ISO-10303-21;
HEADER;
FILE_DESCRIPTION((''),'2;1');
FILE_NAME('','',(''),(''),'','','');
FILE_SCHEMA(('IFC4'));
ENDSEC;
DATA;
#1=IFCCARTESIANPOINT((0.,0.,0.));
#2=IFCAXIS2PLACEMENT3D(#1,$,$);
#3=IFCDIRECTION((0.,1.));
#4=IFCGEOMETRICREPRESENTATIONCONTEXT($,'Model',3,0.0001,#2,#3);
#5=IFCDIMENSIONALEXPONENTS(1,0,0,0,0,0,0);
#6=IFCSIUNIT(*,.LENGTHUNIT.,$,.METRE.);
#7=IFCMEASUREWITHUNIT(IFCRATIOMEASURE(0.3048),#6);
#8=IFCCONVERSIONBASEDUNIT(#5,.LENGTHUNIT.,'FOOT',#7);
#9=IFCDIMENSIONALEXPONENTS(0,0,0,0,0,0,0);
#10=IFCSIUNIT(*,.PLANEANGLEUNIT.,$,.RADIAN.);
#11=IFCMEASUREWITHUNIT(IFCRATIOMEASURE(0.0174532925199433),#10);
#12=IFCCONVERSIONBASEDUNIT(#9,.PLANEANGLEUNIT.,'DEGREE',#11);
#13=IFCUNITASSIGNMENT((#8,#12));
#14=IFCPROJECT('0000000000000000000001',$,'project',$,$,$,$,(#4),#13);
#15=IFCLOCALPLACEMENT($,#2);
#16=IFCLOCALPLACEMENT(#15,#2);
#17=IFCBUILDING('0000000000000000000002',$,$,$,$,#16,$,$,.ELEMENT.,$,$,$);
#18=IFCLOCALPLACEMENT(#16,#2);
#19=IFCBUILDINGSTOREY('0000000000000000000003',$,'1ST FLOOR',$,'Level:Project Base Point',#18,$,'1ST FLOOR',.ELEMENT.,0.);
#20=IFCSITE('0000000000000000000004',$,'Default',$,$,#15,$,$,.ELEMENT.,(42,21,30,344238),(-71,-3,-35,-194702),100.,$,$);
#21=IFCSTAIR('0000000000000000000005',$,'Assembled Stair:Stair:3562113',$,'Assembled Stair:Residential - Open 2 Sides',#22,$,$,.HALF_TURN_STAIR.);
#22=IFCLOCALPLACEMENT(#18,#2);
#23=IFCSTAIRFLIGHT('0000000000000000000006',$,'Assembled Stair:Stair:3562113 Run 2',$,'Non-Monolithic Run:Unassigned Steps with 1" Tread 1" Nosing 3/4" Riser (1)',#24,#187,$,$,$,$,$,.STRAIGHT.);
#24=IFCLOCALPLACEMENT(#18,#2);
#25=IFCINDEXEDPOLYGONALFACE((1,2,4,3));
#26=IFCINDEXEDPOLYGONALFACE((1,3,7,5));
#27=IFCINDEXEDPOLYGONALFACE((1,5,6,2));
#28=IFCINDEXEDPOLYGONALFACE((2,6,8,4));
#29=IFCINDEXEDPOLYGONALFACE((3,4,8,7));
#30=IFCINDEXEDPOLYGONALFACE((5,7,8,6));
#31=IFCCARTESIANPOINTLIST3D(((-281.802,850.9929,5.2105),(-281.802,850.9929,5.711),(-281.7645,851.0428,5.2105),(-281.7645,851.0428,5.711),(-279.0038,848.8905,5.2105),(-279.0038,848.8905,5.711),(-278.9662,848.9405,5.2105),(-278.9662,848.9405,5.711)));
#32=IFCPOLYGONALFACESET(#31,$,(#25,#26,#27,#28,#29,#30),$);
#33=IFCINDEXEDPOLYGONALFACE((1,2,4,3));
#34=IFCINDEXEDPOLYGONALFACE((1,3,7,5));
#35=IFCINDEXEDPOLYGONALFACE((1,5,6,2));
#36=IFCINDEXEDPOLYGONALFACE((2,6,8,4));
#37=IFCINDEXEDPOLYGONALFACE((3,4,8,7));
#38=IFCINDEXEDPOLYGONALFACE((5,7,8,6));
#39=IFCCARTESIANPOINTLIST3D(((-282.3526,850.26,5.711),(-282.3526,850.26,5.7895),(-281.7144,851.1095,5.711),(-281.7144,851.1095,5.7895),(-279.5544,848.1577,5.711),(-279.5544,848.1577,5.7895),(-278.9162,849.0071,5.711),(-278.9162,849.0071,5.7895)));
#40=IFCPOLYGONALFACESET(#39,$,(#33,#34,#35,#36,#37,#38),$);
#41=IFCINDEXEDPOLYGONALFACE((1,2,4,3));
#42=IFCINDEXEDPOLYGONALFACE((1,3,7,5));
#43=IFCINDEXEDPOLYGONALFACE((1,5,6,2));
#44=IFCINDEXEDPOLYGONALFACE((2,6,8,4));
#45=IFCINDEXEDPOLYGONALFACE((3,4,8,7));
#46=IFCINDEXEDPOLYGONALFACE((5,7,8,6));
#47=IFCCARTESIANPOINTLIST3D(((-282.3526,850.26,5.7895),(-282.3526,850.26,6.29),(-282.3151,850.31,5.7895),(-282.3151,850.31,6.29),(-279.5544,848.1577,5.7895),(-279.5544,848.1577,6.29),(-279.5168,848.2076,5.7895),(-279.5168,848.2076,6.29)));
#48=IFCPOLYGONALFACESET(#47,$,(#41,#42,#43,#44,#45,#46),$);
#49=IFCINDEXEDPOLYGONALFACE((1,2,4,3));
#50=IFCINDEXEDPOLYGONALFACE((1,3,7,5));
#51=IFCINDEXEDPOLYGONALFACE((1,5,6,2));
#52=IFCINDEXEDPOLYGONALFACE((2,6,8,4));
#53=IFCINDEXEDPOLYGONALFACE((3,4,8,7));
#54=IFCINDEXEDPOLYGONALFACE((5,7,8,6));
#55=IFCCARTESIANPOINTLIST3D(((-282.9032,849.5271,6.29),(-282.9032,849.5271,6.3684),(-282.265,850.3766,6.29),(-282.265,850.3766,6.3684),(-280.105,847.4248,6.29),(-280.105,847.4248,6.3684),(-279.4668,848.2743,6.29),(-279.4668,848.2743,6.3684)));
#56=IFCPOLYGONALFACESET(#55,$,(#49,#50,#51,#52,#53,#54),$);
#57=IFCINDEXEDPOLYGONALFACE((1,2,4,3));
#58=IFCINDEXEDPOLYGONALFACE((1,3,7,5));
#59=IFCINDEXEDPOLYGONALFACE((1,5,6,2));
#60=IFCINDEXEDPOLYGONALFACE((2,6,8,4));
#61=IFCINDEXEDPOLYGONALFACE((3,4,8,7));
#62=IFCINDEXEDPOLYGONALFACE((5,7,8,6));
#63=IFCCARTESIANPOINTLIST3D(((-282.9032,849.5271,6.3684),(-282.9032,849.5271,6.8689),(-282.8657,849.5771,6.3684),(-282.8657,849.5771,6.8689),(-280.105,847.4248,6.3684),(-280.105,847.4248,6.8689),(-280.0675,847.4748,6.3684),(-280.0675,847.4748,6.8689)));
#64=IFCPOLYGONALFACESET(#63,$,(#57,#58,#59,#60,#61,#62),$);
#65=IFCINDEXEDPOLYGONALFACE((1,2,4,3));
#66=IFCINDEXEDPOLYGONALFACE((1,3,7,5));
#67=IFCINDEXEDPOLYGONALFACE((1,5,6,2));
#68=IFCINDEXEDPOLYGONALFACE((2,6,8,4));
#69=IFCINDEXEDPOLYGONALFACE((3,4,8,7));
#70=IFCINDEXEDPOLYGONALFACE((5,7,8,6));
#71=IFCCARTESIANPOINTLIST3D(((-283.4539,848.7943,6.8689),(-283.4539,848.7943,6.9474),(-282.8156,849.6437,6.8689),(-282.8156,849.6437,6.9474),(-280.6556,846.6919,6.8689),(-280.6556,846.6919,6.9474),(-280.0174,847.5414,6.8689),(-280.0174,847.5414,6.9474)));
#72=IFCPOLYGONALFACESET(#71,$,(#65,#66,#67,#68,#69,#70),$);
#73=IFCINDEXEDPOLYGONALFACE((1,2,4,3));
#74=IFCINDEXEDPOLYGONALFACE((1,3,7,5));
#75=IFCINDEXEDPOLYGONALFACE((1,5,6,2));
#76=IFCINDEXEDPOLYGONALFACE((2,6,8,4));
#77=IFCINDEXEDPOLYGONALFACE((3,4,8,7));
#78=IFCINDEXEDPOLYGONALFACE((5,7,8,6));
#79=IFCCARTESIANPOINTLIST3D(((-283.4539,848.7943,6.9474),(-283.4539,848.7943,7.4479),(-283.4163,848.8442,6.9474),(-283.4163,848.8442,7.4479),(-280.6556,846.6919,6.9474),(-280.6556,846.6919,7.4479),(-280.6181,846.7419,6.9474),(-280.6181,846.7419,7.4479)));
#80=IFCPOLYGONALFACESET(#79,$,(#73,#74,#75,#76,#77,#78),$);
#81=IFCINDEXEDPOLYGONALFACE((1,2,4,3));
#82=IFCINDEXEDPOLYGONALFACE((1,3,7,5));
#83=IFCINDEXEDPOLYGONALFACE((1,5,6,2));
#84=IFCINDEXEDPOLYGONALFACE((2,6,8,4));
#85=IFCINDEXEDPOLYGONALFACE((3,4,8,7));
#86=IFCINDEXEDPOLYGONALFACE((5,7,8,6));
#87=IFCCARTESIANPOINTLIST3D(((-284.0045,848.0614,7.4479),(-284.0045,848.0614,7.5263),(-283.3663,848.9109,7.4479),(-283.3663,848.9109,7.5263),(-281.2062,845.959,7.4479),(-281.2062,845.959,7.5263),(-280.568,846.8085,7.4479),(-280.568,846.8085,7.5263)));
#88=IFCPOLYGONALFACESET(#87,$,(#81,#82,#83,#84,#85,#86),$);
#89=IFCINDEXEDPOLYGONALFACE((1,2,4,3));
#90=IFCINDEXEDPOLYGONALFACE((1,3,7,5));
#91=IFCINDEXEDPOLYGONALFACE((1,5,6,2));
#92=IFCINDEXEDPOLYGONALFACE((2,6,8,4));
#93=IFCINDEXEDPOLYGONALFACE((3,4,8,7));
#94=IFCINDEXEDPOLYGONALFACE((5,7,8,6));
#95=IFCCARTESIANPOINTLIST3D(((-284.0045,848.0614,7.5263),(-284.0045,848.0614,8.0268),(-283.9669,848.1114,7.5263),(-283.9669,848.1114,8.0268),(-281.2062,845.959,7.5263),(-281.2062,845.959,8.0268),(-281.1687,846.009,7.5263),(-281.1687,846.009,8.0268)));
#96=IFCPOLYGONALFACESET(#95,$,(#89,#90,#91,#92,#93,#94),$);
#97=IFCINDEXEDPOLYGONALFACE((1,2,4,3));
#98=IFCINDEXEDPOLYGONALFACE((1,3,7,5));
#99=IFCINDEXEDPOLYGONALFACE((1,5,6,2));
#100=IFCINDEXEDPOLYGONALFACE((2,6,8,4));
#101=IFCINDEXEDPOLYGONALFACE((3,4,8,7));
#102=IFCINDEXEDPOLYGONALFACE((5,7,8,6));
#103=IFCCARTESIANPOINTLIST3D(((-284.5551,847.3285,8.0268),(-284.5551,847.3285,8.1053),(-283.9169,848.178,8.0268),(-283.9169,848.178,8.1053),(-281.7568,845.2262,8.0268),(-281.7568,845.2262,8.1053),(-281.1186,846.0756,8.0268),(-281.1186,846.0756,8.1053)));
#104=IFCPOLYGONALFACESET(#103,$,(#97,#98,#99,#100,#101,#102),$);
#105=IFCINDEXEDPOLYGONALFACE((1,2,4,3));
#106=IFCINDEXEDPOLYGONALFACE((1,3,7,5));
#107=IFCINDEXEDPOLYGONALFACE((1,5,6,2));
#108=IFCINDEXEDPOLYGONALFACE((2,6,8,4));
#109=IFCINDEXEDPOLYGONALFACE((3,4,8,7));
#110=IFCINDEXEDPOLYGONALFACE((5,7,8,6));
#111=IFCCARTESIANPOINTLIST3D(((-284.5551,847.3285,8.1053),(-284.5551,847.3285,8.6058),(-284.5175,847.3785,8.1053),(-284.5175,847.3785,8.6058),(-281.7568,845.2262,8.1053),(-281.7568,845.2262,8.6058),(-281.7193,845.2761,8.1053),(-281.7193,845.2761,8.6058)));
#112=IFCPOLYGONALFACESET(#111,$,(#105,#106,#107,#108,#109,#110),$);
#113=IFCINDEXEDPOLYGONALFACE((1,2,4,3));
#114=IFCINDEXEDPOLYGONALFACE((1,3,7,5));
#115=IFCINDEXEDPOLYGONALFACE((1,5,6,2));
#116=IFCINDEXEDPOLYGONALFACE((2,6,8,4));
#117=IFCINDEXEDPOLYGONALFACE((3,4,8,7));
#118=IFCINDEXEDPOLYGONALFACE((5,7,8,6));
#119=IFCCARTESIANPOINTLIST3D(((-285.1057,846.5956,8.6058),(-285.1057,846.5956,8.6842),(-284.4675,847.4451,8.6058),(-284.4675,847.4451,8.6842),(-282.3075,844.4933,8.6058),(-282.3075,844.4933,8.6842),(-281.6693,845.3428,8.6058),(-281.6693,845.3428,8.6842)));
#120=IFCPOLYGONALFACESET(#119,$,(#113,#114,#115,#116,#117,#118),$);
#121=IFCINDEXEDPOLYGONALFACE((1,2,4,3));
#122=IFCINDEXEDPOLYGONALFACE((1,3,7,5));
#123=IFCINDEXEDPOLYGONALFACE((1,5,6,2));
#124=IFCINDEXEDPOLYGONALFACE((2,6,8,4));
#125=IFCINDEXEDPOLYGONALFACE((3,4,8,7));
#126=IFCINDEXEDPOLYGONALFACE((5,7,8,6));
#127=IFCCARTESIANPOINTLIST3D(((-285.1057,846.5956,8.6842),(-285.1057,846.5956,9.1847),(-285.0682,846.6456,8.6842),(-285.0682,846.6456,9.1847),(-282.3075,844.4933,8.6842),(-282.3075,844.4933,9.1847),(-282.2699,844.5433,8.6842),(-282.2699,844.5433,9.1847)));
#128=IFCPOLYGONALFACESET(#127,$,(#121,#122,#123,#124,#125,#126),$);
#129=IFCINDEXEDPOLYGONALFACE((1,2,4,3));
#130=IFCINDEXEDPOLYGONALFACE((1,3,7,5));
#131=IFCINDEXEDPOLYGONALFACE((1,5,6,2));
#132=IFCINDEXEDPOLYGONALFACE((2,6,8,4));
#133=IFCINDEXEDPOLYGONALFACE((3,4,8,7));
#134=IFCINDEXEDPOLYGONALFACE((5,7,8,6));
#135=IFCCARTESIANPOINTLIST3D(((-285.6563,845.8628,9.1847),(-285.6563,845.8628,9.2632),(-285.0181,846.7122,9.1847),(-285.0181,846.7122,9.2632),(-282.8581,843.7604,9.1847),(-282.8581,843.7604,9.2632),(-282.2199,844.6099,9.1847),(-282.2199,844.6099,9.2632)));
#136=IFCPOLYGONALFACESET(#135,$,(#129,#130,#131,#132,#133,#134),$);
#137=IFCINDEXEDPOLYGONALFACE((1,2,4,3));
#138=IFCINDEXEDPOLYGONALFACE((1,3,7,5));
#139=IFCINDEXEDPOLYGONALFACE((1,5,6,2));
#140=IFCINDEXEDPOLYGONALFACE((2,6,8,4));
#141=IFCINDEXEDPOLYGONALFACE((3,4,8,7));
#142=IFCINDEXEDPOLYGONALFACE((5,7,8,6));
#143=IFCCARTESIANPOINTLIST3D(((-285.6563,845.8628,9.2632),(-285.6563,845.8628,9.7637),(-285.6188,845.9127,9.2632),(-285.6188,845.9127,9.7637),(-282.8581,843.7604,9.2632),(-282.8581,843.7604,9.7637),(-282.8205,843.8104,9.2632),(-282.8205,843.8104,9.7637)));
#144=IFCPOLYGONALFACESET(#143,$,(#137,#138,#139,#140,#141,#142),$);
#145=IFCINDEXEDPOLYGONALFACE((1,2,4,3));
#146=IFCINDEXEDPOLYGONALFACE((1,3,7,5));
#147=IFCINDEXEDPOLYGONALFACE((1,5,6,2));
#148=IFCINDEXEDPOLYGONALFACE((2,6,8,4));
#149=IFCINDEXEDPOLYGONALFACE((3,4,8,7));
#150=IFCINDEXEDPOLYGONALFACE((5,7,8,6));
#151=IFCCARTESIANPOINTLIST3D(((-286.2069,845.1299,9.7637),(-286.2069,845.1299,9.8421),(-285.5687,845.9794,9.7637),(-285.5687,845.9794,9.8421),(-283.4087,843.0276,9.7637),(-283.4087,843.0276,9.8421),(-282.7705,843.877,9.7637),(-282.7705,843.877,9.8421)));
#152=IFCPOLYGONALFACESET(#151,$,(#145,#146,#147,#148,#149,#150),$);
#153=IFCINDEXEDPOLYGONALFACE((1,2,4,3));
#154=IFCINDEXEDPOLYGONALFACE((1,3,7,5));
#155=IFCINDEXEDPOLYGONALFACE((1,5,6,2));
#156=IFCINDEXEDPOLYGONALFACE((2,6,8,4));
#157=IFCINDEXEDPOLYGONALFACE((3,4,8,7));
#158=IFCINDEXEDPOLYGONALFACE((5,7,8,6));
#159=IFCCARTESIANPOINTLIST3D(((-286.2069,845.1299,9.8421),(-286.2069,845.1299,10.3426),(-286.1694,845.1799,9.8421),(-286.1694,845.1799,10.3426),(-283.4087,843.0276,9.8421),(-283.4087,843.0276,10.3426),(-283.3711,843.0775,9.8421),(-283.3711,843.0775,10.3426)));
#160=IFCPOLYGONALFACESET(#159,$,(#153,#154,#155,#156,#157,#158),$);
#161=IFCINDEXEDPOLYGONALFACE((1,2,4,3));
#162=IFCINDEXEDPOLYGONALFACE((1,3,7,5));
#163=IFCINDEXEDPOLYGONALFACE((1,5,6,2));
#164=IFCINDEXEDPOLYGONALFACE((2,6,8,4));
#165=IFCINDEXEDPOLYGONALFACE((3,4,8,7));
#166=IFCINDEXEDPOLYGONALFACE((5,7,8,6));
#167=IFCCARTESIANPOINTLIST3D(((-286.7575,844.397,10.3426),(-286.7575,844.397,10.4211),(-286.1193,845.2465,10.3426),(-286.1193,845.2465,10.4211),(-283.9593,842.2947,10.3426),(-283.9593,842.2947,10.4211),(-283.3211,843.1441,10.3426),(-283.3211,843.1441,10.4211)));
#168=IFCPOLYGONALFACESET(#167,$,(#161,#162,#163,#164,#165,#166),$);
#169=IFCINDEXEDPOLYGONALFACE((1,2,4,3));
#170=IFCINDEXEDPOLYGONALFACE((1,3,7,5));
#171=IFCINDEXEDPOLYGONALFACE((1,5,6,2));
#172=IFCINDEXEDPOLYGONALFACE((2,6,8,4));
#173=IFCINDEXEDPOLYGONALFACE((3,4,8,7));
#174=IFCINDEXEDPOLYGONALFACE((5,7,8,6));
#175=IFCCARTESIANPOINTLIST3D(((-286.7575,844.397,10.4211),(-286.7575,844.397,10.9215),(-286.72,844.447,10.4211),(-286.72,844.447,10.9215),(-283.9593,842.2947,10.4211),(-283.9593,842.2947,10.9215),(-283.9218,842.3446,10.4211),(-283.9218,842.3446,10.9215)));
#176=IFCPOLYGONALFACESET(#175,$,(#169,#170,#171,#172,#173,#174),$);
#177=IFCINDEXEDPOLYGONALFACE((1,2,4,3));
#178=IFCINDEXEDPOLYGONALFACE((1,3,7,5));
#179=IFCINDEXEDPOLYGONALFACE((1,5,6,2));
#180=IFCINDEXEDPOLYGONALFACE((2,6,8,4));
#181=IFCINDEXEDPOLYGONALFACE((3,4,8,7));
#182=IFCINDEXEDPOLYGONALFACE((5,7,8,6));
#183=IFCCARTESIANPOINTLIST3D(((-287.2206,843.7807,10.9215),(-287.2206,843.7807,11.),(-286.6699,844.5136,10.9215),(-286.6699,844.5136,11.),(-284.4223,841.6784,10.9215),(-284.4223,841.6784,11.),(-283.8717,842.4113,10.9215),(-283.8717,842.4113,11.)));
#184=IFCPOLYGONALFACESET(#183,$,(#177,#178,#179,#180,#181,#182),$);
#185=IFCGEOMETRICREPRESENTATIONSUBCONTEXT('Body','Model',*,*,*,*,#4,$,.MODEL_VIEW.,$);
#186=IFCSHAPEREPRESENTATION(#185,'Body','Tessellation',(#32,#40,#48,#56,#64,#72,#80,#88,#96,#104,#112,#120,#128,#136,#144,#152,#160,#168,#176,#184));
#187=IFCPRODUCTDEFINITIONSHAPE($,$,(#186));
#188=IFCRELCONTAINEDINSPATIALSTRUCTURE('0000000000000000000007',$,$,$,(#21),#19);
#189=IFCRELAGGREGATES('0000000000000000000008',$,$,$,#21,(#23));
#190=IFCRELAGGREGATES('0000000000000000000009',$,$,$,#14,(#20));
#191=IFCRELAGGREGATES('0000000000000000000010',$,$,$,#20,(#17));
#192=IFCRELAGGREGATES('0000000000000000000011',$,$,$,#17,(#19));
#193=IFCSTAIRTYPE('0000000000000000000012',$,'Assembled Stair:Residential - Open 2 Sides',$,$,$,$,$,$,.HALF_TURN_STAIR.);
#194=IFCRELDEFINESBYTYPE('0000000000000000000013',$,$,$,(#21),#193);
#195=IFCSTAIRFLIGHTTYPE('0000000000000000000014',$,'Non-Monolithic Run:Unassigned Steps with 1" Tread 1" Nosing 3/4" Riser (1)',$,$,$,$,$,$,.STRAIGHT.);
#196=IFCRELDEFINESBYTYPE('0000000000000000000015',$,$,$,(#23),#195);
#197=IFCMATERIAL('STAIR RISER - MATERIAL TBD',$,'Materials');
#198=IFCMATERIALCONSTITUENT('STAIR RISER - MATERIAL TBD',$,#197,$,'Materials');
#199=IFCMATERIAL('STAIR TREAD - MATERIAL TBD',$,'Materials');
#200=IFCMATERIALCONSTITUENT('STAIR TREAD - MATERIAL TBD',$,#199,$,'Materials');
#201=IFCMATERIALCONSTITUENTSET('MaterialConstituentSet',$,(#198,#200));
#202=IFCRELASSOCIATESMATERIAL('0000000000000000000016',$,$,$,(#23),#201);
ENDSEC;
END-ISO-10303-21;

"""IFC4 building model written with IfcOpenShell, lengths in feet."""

from ifc_helpers import new_model, entity, si_unit, converted_unit, direction, frame, frame_2d, origin, origin_2d_with_axis, place, context, subcontext, project, spatial, rectangle, extrude, material, constituent, constituent_set, type_object, element, aggregate, save


model = new_model("IFC4")

# Units and contexts
model_context = context("Model", 3, precision=0.0001, world=origin(), true_north=direction((0.0, 1.0)))
body_context = subcontext(model_context, "Body", "Model", "MODEL_VIEW")
ifc_project = project(units=[converted_unit("LENGTHUNIT", "FOOT", entity("IfcRatioMeasure", 0.3048), si_unit("LENGTHUNIT", "METRE"), dimensions=[1, 0, 0, 0, 0, 0, 0]), converted_unit("PLANEANGLEUNIT", "DEGREE", entity("IfcRatioMeasure", 0.0174532925199433), si_unit("PLANEANGLEUNIT", "RADIAN"), dimensions=[0, 0, 0, 0, 0, 0, 0])], contexts=[model_context])

# Site, building, storey
site_placement = place(None, origin())
site = spatial("IfcSite", under=ifc_project, at=site_placement, Name="Default", CompositionType="ELEMENT", RefLatitude=(42, 21, 30, 344238), RefLongitude=(-71, -3, -35, -194702), RefElevation=100.0)
building_placement = place(site_placement, origin())
building = spatial("IfcBuilding", under=site, at=building_placement, CompositionType="ELEMENT")
storey_placement = place(building_placement, origin())
storey = spatial("IfcBuildingStorey", under=building, at=storey_placement, Name="1ST FLOOR", ObjectType="Level:Project Base Point", LongName="1ST FLOOR", CompositionType="ELEMENT", Elevation=0.0)

# Stair
stair_type = type_object("IfcStairType", Name="Assembled Stair:Residential - Open 2 Sides", PredefinedType="HALF_TURN_STAIR")
stair_placement = place(storey_placement, origin())
stair = element("IfcStair", 1, at=stair_placement, inside=storey, type_object=stair_type, Name="Assembled Stair:Stair:3562113", ObjectType="Assembled Stair:Residential - Open 2 Sides", PredefinedType="HALF_TURN_STAIR")
ifc_material_1 = material(Name="STAIR TREAD - MATERIAL TBD", Category="Materials")

# Stair flight
ifc_material_2 = material(Name="STAIR RISER - MATERIAL TBD", Category="Materials")
ifc_constituent_1 = constituent(ifc_material_2, Name="STAIR RISER - MATERIAL TBD", Category="Materials")
ifc_constituent_2 = constituent(ifc_material_1, Name="STAIR TREAD - MATERIAL TBD", Category="Materials")
ifc_constituent_set_1 = constituent_set(constituents=[ifc_constituent_1, ifc_constituent_2], Name="MaterialConstituentSet")
stair_flight_type_1 = type_object("IfcStairFlightType", Name="Non-Monolithic Run:Unassigned Steps with 1\" Tread 1\" Nosing 3/4\" Riser (1)", PredefinedType="STRAIGHT")
stair_flight_1_placement = place(stair_placement, frame((-287.2206, 841.6784, 0.0)))
stair_flight_1 = element("IfcStairFlight", 2, at=stair_flight_1_placement, type_object=stair_flight_type_1, material=ifc_constituent_set_1, Name="Assembled Stair:Stair:3562113 Run 2", ObjectType="Non-Monolithic Run:Unassigned Steps with 1\" Tread 1\" Nosing 3/4\" Riser (1)", PredefinedType="STRAIGHT", context=body_context, shape_type="SweptSolid", body=[
    extrude(rectangle(XDim=3.5, YDim=0.0625, at=frame_2d((0.0, 0.0), x_axis=(1.0, 0.0))), frame((6.8364, 8.2883, 5.2105), z_axis=(0.0, 0.0, 1.0), x_axis=(0.799497, -0.60067, 0.0)), (0.0, 0.0, 1.0), 0.5005),
    extrude(rectangle(XDim=1.0625, YDim=3.5, at=frame_2d((0.0, 0.0), x_axis=(1.0, 0.0))), frame((6.5862, 7.9552, 5.711), z_axis=(0.0, 0.0, 1.0), x_axis=(0.60067, 0.799497, 0.0)), (0.0, 0.0, 1.0), 0.0785),
    extrude(rectangle(XDim=3.5, YDim=0.0625, at=origin_2d_with_axis()), frame((6.2858, 7.5554, 5.7895), z_axis=(0.0, 0.0, 1.0), x_axis=(0.799497, -0.60067, 0.0)), (0.0, 0.0, 1.0), 0.5005),
    extrude(rectangle(XDim=1.0625, YDim=3.5, at=origin_2d_with_axis()), frame((6.0355, 7.2223, 6.29), z_axis=(0.0, 0.0, 1.0), x_axis=(0.60067, 0.799497, 0.0)), (0.0, 0.0, 1.0), 0.0785),
    extrude(rectangle(XDim=3.5, YDim=0.0625, at=origin_2d_with_axis()), frame((5.7352, 6.8225, 6.3684), z_axis=(0.0, 0.0, 1.0), x_axis=(0.799497, -0.60067, 0.0)), (0.0, 0.0, 1.0), 0.5005),
    extrude(rectangle(XDim=1.0625, YDim=3.5, at=frame_2d((0.0, 0.0), x_axis=(1.0, 0.0))), frame((5.4849, 6.4894, 6.8689), z_axis=(0.0, 0.0, 1.0), x_axis=(0.60067, 0.799497, 0.0)), (0.0, 0.0, 1.0), 0.0785),
    extrude(rectangle(XDim=3.5, YDim=0.0625, at=origin_2d_with_axis()), frame((5.1846, 6.0897, 6.9474), z_axis=(0.0, 0.0, 1.0), x_axis=(0.799497, -0.60067, 0.0)), (0.0, 0.0, 1.0), 0.5005),
    extrude(rectangle(XDim=1.0625, YDim=3.5, at=frame_2d((0.0, 0.0), x_axis=(1.0, 0.0))), frame((4.9343, 5.7565, 7.4479), z_axis=(0.0, 0.0, 1.0), x_axis=(0.60067, 0.799497, 0.0)), (0.0, 0.0, 1.0), 0.0785),
    extrude(rectangle(XDim=3.5, YDim=0.0625, at=origin_2d_with_axis()), frame((4.634, 5.3568, 7.5263), z_axis=(0.0, 0.0, 1.0), x_axis=(0.799497, -0.60067, 0.0)), (0.0, 0.0, 1.0), 0.5005),
    extrude(rectangle(XDim=1.0625, YDim=3.5, at=origin_2d_with_axis()), frame((4.3837, 5.0237, 8.0268), z_axis=(0.0, 0.0, 1.0), x_axis=(0.60067, 0.799497, 0.0)), (0.0, 0.0, 1.0), 0.0785),
    extrude(rectangle(XDim=3.5, YDim=0.0625, at=origin_2d_with_axis()), frame((4.0834, 4.6239, 8.1053), z_axis=(0.0, 0.0, 1.0), x_axis=(0.799497, -0.60067, 0.0)), (0.0, 0.0, 1.0), 0.5005),
    extrude(rectangle(XDim=1.0625, YDim=3.5, at=frame_2d((0.0, 0.0), x_axis=(1.0, 0.0))), frame((3.8331, 4.2908, 8.6058), z_axis=(0.0, 0.0, 1.0), x_axis=(0.60067, 0.799497, 0.0)), (0.0, 0.0, 1.0), 0.0785),
    extrude(rectangle(XDim=3.5, YDim=0.0625, at=origin_2d_with_axis()), frame((3.5327, 3.8911, 8.6842), z_axis=(0.0, 0.0, 1.0), x_axis=(0.799497, -0.60067, 0.0)), (0.0, 0.0, 1.0), 0.5005),
    extrude(rectangle(XDim=1.0625, YDim=3.5, at=origin_2d_with_axis()), frame((3.2825, 3.5579, 9.1847), z_axis=(0.0, 0.0, 1.0), x_axis=(0.60067, 0.799497, 0.0)), (0.0, 0.0, 1.0), 0.0785),
    extrude(rectangle(XDim=3.5, YDim=0.0625, at=origin_2d_with_axis()), frame((2.9821, 3.1582, 9.2632), z_axis=(0.0, 0.0, 1.0), x_axis=(0.799497, -0.60067, 0.0)), (0.0, 0.0, 1.0), 0.5005),
    extrude(rectangle(XDim=1.0625, YDim=3.5, at=origin_2d_with_axis()), frame((2.7319, 2.8251, 9.7637), z_axis=(0.0, 0.0, 1.0), x_axis=(0.60067, 0.799497, 0.0)), (0.0, 0.0, 1.0), 0.0785),
    extrude(rectangle(XDim=3.5, YDim=0.0625, at=origin_2d_with_axis()), frame((2.4315, 2.4253, 9.8421), z_axis=(0.0, 0.0, 1.0), x_axis=(0.799497, -0.60067, 0.0)), (0.0, 0.0, 1.0), 0.5005),
    extrude(rectangle(XDim=1.0625, YDim=3.5, at=frame_2d((0.0, 0.0), x_axis=(1.0, 0.0))), frame((2.1812, 2.0922, 10.3426), z_axis=(0.0, 0.0, 1.0), x_axis=(0.60067, 0.799497, 0.0)), (0.0, 0.0, 1.0), 0.0785),
    extrude(rectangle(XDim=3.5, YDim=0.0625, at=frame_2d((0.0, 0.0), x_axis=(1.0, 0.0))), frame((1.8809, 1.6924, 10.4211), z_axis=(0.0, 0.0, 1.0), x_axis=(0.799497, -0.60067, 0.0)), (0.0, 0.0, 1.0), 0.5005),
    extrude(rectangle(XDim=0.9167, YDim=3.5, at=frame_2d((0.0, 0.0), x_axis=(1.0, 0.0))), frame((1.6744, 1.4176, 10.9215), z_axis=(0.0, 0.0, 1.0), x_axis=(0.60067, 0.799497, 0.0)), (0.0, 0.0, 1.0), 0.0785),
])
aggregate(stair, [stair_flight_1])

save(model, "model.ifc")
